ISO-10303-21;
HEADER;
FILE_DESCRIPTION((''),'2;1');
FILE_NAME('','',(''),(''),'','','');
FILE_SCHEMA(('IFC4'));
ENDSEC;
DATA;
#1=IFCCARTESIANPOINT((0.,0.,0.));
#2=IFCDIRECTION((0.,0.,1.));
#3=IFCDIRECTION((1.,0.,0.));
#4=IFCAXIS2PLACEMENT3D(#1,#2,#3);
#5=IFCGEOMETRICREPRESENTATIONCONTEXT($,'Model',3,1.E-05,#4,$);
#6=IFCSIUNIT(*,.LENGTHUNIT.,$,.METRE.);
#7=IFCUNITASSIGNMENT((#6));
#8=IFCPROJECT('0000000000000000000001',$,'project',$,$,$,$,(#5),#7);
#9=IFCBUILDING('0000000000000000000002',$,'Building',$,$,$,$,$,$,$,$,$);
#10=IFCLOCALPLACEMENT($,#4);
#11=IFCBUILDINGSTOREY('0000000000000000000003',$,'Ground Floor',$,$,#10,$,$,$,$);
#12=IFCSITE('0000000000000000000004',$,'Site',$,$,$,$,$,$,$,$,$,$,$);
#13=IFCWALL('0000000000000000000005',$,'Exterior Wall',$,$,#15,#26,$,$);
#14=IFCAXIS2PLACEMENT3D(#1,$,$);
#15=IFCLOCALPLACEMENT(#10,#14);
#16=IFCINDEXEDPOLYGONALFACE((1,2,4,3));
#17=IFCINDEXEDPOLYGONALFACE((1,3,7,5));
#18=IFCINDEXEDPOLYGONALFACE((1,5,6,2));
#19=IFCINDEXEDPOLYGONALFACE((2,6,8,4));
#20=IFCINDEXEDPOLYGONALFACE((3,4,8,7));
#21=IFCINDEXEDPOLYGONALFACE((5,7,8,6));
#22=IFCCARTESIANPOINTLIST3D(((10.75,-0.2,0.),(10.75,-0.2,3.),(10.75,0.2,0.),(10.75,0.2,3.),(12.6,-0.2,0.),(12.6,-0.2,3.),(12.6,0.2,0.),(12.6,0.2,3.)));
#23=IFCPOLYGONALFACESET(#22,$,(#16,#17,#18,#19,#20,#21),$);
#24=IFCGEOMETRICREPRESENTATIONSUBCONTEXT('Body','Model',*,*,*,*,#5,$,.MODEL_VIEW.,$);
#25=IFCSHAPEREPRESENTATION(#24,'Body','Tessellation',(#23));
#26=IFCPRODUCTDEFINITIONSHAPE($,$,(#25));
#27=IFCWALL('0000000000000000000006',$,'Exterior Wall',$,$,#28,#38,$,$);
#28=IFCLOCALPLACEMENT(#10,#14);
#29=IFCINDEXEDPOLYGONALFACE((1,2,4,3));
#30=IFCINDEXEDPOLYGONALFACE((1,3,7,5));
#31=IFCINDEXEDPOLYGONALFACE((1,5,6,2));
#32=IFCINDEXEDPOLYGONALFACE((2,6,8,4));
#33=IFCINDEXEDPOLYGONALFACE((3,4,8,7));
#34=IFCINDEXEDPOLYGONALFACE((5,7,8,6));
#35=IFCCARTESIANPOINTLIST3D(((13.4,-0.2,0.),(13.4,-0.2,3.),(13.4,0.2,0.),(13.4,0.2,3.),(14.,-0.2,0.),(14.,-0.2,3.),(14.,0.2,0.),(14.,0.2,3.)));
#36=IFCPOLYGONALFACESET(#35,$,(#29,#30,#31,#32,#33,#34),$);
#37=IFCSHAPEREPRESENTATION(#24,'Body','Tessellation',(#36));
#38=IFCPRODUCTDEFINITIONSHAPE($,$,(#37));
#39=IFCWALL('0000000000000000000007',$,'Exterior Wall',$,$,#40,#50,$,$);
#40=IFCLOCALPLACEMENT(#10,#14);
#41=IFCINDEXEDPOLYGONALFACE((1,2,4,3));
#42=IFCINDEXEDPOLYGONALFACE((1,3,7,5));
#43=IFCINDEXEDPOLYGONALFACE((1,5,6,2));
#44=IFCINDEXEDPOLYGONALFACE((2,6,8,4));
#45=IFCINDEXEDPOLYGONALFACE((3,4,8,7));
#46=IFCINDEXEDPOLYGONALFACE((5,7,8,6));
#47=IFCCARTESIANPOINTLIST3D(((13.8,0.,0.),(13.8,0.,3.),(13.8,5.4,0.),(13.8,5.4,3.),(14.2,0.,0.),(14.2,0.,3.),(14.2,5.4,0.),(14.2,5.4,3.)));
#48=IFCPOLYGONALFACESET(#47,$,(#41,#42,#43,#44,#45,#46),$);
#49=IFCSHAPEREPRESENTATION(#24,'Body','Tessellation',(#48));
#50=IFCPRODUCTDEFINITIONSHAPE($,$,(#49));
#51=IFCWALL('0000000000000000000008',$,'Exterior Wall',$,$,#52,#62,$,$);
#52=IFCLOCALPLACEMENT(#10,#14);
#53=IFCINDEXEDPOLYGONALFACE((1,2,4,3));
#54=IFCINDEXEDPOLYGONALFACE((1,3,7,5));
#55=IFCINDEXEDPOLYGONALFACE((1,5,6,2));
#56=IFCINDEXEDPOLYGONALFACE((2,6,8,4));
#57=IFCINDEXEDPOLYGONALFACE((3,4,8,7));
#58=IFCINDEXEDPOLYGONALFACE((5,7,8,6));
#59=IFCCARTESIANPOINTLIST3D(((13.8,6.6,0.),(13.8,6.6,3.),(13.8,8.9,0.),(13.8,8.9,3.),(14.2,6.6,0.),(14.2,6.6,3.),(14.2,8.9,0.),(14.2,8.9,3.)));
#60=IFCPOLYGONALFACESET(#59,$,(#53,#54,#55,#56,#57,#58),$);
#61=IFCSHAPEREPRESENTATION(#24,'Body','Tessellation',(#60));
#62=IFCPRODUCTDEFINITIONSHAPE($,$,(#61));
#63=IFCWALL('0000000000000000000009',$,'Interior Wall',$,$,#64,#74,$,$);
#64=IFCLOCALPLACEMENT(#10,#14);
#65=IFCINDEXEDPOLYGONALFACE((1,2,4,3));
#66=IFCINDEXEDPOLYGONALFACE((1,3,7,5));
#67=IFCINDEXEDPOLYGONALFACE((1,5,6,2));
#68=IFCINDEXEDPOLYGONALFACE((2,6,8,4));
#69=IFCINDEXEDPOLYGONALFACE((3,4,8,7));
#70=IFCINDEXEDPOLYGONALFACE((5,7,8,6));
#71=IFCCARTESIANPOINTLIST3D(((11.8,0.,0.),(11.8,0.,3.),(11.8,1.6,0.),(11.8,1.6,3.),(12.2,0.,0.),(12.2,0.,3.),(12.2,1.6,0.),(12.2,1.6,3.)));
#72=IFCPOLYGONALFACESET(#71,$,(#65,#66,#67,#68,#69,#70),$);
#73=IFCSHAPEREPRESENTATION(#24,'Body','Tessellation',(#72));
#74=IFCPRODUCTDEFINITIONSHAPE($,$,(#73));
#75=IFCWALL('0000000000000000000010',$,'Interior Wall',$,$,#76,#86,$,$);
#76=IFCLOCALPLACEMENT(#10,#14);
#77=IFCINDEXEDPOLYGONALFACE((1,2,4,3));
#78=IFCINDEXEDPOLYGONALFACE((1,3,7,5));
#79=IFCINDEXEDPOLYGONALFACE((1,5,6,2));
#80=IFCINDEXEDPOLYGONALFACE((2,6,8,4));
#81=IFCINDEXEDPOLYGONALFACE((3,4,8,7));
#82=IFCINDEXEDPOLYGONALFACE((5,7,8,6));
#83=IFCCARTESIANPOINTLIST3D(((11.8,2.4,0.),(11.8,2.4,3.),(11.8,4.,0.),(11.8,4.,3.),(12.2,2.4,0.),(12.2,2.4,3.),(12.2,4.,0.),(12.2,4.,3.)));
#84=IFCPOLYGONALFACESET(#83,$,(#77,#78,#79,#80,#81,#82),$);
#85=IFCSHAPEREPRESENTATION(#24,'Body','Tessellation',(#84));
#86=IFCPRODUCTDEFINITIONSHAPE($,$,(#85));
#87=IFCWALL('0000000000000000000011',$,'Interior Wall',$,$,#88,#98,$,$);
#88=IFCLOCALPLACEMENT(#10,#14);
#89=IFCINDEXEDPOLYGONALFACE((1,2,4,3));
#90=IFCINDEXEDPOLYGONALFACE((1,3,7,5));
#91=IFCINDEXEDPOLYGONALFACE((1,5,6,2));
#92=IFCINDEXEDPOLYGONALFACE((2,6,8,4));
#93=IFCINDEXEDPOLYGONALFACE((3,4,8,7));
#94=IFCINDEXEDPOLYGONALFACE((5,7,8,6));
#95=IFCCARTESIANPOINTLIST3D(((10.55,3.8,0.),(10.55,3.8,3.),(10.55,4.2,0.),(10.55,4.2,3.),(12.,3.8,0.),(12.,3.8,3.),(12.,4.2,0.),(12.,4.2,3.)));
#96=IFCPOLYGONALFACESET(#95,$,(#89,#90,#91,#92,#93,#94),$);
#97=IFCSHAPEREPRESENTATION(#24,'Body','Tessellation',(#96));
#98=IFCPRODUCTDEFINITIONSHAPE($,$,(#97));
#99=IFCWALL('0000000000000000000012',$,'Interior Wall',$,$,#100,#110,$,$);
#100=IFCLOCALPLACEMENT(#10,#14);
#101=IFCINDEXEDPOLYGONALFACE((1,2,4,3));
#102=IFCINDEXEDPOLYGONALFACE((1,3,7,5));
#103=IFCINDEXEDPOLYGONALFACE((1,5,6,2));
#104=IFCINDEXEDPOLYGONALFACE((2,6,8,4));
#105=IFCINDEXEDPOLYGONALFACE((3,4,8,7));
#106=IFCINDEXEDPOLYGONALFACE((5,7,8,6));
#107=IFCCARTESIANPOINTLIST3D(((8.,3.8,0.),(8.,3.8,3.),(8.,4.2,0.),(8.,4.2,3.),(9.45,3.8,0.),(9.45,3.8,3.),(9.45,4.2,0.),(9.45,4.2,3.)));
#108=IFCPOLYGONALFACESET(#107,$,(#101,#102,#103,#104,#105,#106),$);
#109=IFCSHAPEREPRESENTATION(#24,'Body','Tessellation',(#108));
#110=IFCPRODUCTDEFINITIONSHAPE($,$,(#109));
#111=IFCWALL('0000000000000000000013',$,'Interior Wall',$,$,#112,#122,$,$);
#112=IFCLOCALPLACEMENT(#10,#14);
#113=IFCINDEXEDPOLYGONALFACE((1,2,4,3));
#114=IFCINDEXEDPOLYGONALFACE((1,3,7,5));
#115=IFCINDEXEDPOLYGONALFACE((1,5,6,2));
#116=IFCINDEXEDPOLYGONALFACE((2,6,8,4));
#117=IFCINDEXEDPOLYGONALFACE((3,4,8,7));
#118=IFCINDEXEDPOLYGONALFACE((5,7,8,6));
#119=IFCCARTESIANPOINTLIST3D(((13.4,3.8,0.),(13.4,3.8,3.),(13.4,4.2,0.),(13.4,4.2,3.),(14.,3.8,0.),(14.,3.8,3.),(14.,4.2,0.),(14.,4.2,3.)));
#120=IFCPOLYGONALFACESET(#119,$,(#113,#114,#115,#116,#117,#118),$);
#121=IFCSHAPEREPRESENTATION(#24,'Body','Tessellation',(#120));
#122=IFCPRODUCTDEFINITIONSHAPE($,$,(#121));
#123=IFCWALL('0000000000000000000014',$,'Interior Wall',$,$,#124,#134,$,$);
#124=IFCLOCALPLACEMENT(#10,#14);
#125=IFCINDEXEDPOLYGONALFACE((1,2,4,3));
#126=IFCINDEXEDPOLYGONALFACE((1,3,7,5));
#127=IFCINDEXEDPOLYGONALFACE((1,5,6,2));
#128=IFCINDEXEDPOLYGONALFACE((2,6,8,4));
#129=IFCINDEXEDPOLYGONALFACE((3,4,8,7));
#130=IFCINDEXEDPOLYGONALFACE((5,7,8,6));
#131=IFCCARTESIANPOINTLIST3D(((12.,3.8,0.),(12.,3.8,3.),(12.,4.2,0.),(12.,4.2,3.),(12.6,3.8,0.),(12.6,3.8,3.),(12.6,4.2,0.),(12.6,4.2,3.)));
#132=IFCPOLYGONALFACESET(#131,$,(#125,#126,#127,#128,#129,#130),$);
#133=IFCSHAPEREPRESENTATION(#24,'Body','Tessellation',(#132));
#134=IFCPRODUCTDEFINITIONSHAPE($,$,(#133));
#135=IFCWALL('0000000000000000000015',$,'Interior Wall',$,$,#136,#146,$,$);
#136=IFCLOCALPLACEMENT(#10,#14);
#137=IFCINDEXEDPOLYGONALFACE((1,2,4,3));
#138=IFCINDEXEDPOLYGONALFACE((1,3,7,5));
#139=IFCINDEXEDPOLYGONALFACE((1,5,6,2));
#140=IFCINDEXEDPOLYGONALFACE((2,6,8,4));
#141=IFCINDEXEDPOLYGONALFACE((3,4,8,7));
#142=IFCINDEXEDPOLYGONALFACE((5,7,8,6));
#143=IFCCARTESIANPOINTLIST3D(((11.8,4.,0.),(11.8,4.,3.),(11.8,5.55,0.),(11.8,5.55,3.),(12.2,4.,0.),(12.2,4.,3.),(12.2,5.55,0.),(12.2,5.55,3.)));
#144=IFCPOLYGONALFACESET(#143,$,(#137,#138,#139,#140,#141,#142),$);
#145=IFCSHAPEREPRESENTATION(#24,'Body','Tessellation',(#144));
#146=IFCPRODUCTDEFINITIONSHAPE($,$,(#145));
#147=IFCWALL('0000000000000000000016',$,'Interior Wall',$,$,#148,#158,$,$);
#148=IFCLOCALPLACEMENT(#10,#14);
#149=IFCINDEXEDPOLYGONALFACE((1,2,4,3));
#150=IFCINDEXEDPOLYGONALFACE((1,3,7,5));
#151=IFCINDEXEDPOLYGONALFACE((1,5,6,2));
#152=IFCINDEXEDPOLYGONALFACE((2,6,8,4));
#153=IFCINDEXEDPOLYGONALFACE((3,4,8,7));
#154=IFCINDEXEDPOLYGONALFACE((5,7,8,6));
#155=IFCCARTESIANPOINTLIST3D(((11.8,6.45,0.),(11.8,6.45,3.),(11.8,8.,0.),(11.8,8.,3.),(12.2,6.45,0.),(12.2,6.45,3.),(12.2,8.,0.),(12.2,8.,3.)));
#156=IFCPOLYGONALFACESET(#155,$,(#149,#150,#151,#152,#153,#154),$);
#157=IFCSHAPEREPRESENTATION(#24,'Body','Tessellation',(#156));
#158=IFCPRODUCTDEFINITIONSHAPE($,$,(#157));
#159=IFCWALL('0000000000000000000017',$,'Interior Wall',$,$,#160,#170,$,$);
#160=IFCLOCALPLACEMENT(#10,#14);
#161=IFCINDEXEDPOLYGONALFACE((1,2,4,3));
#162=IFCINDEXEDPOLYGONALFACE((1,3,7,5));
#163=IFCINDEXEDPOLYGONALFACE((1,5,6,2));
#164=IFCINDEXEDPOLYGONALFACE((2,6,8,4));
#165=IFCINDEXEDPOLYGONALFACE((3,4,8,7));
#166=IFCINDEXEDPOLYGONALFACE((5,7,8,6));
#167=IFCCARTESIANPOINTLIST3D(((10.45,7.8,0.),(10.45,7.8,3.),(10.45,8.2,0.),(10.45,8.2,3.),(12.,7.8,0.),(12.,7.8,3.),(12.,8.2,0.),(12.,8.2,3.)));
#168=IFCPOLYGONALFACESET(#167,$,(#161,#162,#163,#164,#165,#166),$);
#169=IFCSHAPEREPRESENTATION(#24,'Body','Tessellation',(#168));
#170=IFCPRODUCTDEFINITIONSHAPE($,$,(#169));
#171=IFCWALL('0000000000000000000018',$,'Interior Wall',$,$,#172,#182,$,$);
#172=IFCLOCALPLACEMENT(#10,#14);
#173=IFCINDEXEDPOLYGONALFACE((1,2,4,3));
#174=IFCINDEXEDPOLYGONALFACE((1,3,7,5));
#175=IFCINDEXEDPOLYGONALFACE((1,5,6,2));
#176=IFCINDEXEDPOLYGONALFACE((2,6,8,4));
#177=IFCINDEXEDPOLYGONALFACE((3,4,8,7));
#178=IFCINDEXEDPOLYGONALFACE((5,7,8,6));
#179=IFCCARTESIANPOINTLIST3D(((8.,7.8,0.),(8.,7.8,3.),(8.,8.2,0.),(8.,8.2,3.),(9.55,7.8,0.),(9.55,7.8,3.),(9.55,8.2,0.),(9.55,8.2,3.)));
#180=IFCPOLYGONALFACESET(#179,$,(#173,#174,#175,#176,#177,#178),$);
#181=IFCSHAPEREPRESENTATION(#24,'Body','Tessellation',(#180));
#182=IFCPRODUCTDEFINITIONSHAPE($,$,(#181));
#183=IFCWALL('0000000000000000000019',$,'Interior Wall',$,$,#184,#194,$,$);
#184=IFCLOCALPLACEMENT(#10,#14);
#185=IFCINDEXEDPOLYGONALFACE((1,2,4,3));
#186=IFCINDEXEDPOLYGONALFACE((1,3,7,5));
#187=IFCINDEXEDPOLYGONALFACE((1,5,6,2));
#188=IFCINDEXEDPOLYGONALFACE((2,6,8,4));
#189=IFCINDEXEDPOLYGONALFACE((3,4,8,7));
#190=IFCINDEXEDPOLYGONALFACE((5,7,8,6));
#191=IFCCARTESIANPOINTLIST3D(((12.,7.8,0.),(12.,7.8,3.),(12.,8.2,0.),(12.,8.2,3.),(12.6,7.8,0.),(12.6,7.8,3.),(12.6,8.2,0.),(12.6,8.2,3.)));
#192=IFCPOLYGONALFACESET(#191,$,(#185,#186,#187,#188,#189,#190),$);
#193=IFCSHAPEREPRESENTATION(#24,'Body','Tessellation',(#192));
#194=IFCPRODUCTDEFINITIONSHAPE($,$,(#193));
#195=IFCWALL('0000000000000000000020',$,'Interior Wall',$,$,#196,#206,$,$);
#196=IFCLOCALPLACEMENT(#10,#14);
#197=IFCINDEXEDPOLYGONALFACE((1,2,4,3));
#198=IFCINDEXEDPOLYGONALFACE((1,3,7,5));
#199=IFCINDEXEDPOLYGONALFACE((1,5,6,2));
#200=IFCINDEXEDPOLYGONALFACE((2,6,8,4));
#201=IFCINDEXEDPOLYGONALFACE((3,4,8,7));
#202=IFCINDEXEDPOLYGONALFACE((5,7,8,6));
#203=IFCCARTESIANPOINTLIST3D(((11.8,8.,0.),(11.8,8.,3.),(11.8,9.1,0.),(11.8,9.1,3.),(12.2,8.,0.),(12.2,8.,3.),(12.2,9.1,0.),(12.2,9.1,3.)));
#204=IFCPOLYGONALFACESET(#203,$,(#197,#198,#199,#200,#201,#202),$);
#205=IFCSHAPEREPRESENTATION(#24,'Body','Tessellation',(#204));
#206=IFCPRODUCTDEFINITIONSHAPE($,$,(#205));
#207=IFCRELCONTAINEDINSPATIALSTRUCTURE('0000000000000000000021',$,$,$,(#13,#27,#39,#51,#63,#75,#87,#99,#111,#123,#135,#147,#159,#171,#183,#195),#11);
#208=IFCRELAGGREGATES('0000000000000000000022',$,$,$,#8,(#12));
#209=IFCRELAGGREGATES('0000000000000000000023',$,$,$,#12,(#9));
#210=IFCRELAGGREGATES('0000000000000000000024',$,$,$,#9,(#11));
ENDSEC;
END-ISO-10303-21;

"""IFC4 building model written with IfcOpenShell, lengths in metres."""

from ifc_helpers import new_model, si_unit, frame, origin_with_axes, place, context, subcontext, project, spatial, indexed_curve, outline, extrude, element, save


model = new_model("IFC4")

# Units and contexts
model_context = context("Model", 3, precision=1e-05, world=origin_with_axes())
body_context = subcontext(model_context, "Body", "Model", "MODEL_VIEW")
ifc_project = project(units=[si_unit("LENGTHUNIT", "METRE")], contexts=[model_context])

# Site, building, storey
site = spatial("IfcSite", under=ifc_project, Name="Site")
building = spatial("IfcBuilding", under=site, Name="Building")
storey_placement = place(None, origin_with_axes())
storey = spatial("IfcBuildingStorey", under=building, at=storey_placement, Name="Ground Floor")

# Walls
wall_1_placement = place(storey_placement, frame((10.75, 0.0, 0.0), z_axis=(0.0, 0.0, 1.0), x_axis=(1.0, 0.0, 0.0)))
element("IfcWall", 1, at=wall_1_placement, inside=storey, Name="Exterior Wall", context=body_context, shape_type="SweptSolid", body=[
    extrude(outline(indexed_curve([(0.0, 0.0), (0.0, 0.4), (1.85, 0.4), (1.85, 0.0), (0.0, 0.0)], self_intersect=False)), frame((0.0, -0.2, 0.0), z_axis=(0.0, 0.0, 1.0), x_axis=(1.0, 0.0, 0.0)), (0.0, 0.0, 1.0), 3.0),
])
wall_2_placement = place(storey_placement, frame((13.4, 0.0, 0.0), z_axis=(0.0, 0.0, 1.0), x_axis=(1.0, 0.0, 0.0)))
element("IfcWall", 2, at=wall_2_placement, inside=storey, Name="Exterior Wall", context=body_context, shape_type="SweptSolid", body=[
    extrude(outline(indexed_curve([(0.0, 0.0), (0.0, 0.4), (0.6, 0.4), (0.6, 0.0), (0.0, 0.0)], self_intersect=False)), frame((0.0, -0.2, 0.0), z_axis=(0.0, 0.0, 1.0), x_axis=(1.0, 0.0, 0.0)), (0.0, 0.0, 1.0), 3.0),
])
wall_3_placement = place(storey_placement, frame((14.0, 0.0, 0.0), z_axis=(0.0, 0.0, 1.0), x_axis=(0.0, 1.0, 0.0)))
element("IfcWall", 3, at=wall_3_placement, inside=storey, Name="Exterior Wall", context=body_context, shape_type="SweptSolid", body=[
    extrude(outline(indexed_curve([(0.0, 0.0), (0.0, 0.4), (5.4, 0.4), (5.4, 0.0), (0.0, 0.0)], self_intersect=False)), frame((0.0, -0.2, 0.0), z_axis=(0.0, 0.0, 1.0), x_axis=(1.0, 0.0, 0.0)), (0.0, 0.0, 1.0), 3.0),
])
wall_4_placement = place(storey_placement, frame((14.0, 6.6, 0.0), z_axis=(0.0, 0.0, 1.0), x_axis=(0.0, 1.0, 0.0)))
element("IfcWall", 4, at=wall_4_placement, inside=storey, Name="Exterior Wall", context=body_context, shape_type="SweptSolid", body=[
    extrude(outline(indexed_curve([(0.0, 0.0), (0.0, 0.4), (2.3, 0.4), (2.3, 0.0), (0.0, 0.0)], self_intersect=False)), frame((0.0, -0.2, 0.0), z_axis=(0.0, 0.0, 1.0), x_axis=(1.0, 0.0, 0.0)), (0.0, 0.0, 1.0), 3.0),
])
for number, where, z_axis, x_axis, name in (
    (5, (12.0, 0.0, 0.0), (0.0, 0.0, 1.0), (0.0, 1.0, 0.0), "Interior Wall"),
    (6, (12.0, 2.4, 0.0), (0.0, 0.0, 1.0), (0.0, 1.0, 0.0), "Interior Wall"),
):
    element("IfcWall", number, at=place(storey_placement, frame(where, z_axis=z_axis, x_axis=x_axis)), inside=storey, Name=name, context=body_context, shape_type="SweptSolid", body=[
        extrude(outline(indexed_curve([(0.0, 0.0), (0.0, 0.4), (1.6, 0.4), (1.6, 0.0), (0.0, 0.0)], self_intersect=False)), frame((0.0, -0.2, 0.0), z_axis=(0.0, 0.0, 1.0), x_axis=(1.0, 0.0, 0.0)), (0.0, 0.0, 1.0), 3.0),
    ])
for number, where, z_axis, x_axis, name in (
    (7, (12.0, 4.0, 0.0), (0.0, 0.0, 1.0), (-1.0, 0.0, 0.0), "Interior Wall"),
    (8, (9.45, 4.0, 0.0), (0.0, 0.0, 1.0), (-1.0, 0.0, 0.0), "Interior Wall"),
):
    element("IfcWall", number, at=place(storey_placement, frame(where, z_axis=z_axis, x_axis=x_axis)), inside=storey, Name=name, context=body_context, shape_type="SweptSolid", body=[
        extrude(outline(indexed_curve([(0.0, 0.0), (0.0, 0.4), (1.45, 0.4), (1.45, 0.0), (0.0, 0.0)], self_intersect=False)), frame((0.0, -0.2, 0.0), z_axis=(0.0, 0.0, 1.0), x_axis=(1.0, 0.0, 0.0)), (0.0, 0.0, 1.0), 3.0),
    ])
for number, where, z_axis, x_axis, name in (
    (9, (14.0, 4.0, 0.0), (0.0, 0.0, 1.0), (-1.0, 0.0, 0.0), "Interior Wall"),
    (10, (12.6, 4.0, 0.0), (0.0, 0.0, 1.0), (-1.0, 0.0, 0.0), "Interior Wall"),
):
    element("IfcWall", number, at=place(storey_placement, frame(where, z_axis=z_axis, x_axis=x_axis)), inside=storey, Name=name, context=body_context, shape_type="SweptSolid", body=[
        extrude(outline(indexed_curve([(0.0, 0.0), (0.0, 0.4), (0.6, 0.4), (0.6, 0.0), (0.0, 0.0)], self_intersect=False)), frame((0.0, -0.2, 0.0), z_axis=(0.0, 0.0, 1.0), x_axis=(1.0, 0.0, 0.0)), (0.0, 0.0, 1.0), 3.0),
    ])
for number, where, z_axis, x_axis, name in (
    (11, (12.0, 4.0, 0.0), (0.0, 0.0, 1.0), (0.0, 1.0, 0.0), "Interior Wall"),
    (12, (12.0, 6.45, 0.0), (0.0, 0.0, 1.0), (0.0, 1.0, 0.0), "Interior Wall"),
):
    element("IfcWall", number, at=place(storey_placement, frame(where, z_axis=z_axis, x_axis=x_axis)), inside=storey, Name=name, context=body_context, shape_type="SweptSolid", body=[
        extrude(outline(indexed_curve([(0.0, 0.0), (0.0, 0.4), (1.55, 0.4), (1.55, 0.0), (0.0, 0.0)], self_intersect=False)), frame((0.0, -0.2, 0.0), z_axis=(0.0, 0.0, 1.0), x_axis=(1.0, 0.0, 0.0)), (0.0, 0.0, 1.0), 3.0),
    ])
for number, where, z_axis, x_axis, name in (
    (13, (12.0, 8.0, 0.0), (0.0, 0.0, 1.0), (-1.0, 0.0, 0.0), "Interior Wall"),
    (14, (9.55, 8.0, 0.0), (0.0, 0.0, 1.0), (-1.0, 0.0, 0.0), "Interior Wall"),
):
    element("IfcWall", number, at=place(storey_placement, frame(where, z_axis=z_axis, x_axis=x_axis)), inside=storey, Name=name, context=body_context, shape_type="SweptSolid", body=[
        extrude(outline(indexed_curve([(0.0, 0.0), (0.0, 0.4), (1.55, 0.4), (1.55, 0.0), (0.0, 0.0)], self_intersect=False)), frame((0.0, -0.2, 0.0), z_axis=(0.0, 0.0, 1.0), x_axis=(1.0, 0.0, 0.0)), (0.0, 0.0, 1.0), 3.0),
    ])
wall_5_placement = place(storey_placement, frame((12.6, 8.0, 0.0), z_axis=(0.0, 0.0, 1.0), x_axis=(-1.0, 0.0, 0.0)))
element("IfcWall", 15, at=wall_5_placement, inside=storey, Name="Interior Wall", context=body_context, shape_type="SweptSolid", body=[
    extrude(outline(indexed_curve([(0.0, 0.0), (0.0, 0.4), (0.6, 0.4), (0.6, 0.0), (0.0, 0.0)], self_intersect=False)), frame((0.0, -0.2, 0.0), z_axis=(0.0, 0.0, 1.0), x_axis=(1.0, 0.0, 0.0)), (0.0, 0.0, 1.0), 3.0),
])
wall_6_placement = place(storey_placement, frame((12.0, 8.0, 0.0), z_axis=(0.0, 0.0, 1.0), x_axis=(0.0, 1.0, 0.0)))
element("IfcWall", 16, at=wall_6_placement, inside=storey, Name="Interior Wall", context=body_context, shape_type="SweptSolid", body=[
    extrude(outline(indexed_curve([(0.0, 0.0), (0.0, 0.4), (1.1, 0.4), (1.1, 0.0), (0.0, 0.0)], self_intersect=False)), frame((0.0, -0.2, 0.0), z_axis=(0.0, 0.0, 1.0), x_axis=(1.0, 0.0, 0.0)), (0.0, 0.0, 1.0), 3.0),
])

save(model, "model.ifc")
